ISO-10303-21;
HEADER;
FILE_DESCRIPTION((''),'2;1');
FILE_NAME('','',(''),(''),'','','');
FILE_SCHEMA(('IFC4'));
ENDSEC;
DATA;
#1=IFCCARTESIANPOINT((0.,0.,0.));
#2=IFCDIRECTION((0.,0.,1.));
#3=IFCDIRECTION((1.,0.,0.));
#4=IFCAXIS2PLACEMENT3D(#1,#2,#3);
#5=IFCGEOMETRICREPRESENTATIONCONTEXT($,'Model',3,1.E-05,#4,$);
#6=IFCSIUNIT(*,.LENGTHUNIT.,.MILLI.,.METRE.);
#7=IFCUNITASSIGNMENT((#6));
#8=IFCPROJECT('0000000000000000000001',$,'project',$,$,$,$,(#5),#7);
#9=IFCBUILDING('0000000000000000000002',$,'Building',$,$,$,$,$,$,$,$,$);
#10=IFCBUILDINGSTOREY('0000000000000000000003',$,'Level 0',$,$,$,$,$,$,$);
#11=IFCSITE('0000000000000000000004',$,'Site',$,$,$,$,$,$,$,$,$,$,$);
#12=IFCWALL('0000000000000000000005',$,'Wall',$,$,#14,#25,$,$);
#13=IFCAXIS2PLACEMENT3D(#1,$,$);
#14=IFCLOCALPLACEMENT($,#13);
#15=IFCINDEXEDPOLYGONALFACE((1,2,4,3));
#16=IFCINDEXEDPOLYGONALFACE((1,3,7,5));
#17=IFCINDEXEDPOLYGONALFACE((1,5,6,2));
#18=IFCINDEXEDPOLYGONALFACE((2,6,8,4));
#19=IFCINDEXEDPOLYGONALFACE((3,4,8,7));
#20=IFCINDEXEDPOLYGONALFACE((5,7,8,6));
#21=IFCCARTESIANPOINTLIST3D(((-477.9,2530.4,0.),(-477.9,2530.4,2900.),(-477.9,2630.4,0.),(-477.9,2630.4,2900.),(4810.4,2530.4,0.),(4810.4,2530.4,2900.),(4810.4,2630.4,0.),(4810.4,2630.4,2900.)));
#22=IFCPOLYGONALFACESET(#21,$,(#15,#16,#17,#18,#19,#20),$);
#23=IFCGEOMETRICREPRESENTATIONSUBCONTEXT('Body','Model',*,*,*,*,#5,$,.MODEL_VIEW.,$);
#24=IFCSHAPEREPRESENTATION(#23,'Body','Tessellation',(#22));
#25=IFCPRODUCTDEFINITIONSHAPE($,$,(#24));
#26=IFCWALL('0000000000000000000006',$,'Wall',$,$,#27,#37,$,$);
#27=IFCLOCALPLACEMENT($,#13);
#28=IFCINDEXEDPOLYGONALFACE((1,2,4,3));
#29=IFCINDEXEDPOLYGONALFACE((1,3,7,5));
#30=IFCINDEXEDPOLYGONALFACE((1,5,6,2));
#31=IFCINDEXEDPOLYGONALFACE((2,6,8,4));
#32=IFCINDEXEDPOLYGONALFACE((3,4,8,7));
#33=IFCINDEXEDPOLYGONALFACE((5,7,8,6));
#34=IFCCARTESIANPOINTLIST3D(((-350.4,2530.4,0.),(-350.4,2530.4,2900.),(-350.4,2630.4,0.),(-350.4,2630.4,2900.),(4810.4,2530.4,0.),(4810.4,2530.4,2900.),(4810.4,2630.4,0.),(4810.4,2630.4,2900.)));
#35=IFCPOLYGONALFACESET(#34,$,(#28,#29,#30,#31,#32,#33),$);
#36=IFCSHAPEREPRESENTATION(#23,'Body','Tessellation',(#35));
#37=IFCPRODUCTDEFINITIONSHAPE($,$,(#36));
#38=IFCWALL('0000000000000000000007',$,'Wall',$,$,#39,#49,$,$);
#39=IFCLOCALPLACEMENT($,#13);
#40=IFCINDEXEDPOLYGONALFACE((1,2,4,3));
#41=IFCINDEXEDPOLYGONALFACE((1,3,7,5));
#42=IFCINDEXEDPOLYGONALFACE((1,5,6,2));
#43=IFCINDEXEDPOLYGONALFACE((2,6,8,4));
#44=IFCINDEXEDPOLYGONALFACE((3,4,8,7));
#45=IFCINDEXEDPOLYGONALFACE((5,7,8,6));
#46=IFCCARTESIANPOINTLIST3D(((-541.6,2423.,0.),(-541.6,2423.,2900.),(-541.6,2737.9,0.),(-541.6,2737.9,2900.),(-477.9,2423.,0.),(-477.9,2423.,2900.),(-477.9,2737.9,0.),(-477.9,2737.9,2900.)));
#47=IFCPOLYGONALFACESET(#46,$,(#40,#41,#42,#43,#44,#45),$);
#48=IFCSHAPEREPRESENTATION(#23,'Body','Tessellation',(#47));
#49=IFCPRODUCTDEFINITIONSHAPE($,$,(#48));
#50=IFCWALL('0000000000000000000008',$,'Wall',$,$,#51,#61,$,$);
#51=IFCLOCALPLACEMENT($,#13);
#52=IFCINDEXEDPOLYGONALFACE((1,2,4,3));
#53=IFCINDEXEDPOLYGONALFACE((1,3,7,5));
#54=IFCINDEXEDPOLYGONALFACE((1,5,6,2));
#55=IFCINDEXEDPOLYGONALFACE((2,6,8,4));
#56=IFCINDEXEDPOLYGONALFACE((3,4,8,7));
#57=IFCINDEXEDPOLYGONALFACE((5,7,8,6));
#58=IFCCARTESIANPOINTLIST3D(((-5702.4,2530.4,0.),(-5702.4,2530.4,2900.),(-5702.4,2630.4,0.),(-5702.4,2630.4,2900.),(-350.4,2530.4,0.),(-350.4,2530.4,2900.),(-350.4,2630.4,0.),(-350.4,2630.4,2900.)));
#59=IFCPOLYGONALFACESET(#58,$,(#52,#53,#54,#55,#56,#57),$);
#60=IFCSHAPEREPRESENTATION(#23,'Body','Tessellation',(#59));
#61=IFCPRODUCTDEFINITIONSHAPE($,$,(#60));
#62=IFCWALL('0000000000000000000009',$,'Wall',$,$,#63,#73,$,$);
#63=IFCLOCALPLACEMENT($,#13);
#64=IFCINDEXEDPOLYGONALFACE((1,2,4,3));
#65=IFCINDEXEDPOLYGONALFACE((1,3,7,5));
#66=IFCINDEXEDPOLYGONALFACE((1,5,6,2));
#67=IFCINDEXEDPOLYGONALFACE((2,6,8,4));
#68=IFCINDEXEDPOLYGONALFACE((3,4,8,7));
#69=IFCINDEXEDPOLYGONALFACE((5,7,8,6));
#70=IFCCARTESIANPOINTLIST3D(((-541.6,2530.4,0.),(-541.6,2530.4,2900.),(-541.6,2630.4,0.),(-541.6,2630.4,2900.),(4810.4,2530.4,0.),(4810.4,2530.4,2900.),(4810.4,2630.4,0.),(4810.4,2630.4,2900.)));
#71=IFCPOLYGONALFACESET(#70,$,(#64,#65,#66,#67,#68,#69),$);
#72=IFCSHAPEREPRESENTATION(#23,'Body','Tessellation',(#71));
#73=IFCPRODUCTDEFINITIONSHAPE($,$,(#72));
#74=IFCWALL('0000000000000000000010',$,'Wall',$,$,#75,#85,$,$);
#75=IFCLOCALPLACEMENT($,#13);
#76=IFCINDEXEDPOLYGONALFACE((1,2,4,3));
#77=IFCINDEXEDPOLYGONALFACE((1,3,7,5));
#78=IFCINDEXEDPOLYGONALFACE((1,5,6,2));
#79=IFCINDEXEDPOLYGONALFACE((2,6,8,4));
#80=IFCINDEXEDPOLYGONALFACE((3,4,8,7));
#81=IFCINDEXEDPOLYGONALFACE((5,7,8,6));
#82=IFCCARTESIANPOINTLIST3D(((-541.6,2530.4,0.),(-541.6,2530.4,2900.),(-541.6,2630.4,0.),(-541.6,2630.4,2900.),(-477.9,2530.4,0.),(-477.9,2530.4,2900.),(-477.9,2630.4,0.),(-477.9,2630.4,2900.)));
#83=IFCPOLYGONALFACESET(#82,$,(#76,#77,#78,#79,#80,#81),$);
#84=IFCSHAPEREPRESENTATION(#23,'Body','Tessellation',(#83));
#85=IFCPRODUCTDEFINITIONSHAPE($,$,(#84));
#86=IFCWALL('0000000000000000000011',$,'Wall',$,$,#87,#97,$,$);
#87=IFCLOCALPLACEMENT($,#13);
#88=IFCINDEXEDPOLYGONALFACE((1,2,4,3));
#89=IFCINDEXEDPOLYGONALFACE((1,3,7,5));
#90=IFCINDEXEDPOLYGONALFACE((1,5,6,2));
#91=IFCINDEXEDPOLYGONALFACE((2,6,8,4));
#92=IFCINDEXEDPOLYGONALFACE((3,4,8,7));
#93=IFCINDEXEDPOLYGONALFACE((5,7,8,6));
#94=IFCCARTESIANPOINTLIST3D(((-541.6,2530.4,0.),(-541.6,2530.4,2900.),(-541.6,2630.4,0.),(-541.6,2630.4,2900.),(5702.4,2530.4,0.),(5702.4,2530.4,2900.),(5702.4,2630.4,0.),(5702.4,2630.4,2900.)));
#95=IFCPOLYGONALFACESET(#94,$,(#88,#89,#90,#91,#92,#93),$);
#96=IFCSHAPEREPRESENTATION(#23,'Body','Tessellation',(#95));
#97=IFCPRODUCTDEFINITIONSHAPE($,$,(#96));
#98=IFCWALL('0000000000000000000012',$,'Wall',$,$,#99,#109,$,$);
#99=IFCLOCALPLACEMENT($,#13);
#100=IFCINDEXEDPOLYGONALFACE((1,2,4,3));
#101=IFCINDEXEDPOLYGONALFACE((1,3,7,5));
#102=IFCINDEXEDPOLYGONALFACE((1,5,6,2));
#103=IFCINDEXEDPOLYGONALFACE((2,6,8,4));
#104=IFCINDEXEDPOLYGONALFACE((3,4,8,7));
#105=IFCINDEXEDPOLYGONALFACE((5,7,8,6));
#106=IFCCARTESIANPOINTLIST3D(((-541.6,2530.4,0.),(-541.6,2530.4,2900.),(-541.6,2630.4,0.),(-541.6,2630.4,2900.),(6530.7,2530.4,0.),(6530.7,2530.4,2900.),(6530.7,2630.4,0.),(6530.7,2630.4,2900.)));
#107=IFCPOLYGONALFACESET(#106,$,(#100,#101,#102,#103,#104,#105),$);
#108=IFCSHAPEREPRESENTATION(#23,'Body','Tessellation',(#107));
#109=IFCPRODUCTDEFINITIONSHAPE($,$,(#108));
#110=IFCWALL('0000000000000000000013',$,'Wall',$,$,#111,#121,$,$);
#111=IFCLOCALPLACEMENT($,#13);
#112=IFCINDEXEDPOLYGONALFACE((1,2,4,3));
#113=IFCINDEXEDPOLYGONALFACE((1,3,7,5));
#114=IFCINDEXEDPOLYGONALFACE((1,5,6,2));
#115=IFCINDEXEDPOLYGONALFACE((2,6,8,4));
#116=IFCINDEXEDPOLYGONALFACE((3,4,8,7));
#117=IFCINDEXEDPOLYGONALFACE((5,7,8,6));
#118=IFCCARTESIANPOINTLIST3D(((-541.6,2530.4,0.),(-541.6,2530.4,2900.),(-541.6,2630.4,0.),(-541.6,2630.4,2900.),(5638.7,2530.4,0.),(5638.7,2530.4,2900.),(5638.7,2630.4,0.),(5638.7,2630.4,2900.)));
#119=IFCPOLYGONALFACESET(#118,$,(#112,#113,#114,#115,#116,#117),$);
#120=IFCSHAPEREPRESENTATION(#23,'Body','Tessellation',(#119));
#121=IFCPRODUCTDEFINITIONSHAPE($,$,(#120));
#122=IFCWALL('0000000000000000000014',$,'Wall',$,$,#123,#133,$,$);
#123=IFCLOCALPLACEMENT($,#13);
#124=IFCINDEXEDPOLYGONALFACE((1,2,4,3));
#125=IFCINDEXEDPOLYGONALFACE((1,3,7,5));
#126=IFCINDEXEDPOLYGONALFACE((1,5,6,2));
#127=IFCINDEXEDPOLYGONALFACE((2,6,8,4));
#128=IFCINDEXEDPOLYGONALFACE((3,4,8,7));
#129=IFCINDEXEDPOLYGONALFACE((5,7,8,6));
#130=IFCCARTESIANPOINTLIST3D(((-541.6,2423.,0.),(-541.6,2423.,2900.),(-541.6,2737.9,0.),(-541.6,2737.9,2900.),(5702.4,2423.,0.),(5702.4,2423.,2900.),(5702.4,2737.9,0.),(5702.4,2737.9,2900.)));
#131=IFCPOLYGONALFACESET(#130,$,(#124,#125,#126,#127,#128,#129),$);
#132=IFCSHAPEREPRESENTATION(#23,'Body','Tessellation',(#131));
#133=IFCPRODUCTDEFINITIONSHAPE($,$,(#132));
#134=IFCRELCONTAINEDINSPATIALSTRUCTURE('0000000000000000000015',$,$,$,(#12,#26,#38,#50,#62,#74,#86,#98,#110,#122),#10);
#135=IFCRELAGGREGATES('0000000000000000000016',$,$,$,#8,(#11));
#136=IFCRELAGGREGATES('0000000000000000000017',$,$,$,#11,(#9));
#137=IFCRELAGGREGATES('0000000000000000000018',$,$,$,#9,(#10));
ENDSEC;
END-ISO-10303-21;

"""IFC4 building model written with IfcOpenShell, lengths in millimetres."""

from ifc_helpers import new_model, si_unit, frame, origin_with_axes, place, context, subcontext, project, spatial, indexed_curve, outline, extrude, element, save


model = new_model("IFC4")

# Units and contexts
model_context = context("Model", 3, precision=1e-05, world=origin_with_axes())
body_context = subcontext(model_context, "Body", "Model", "MODEL_VIEW")
ifc_project = project(units=[si_unit("LENGTHUNIT", "METRE", prefix="MILLI")], contexts=[model_context])

# Site, building, storey
site = spatial("IfcSite", under=ifc_project, Name="Site")
building = spatial("IfcBuilding", under=site, Name="Building")
storey = spatial("IfcBuildingStorey", under=building, Name="Level 0")

# Walls
wall_1_placement = place(None, frame((-477.9, 2530.4, 0.0), z_axis=(0.0, 0.0, 1.0), x_axis=(1.0, 0.0, 0.0)))
element("IfcWall", 1, at=wall_1_placement, inside=storey, Name="Wall", context=body_context, shape_type="SweptSolid", body=[
    extrude(outline(indexed_curve([(0.0, 0.0), (0.0, 99.9), (5288.3, 99.9), (5288.3, 0.0), (0.0, 0.0)], self_intersect=False)), origin_with_axes(), (0.0, 0.0, 1.0), 2900.0),
])
wall_2_placement = place(None, frame((-350.4, 2530.4, 0.0), z_axis=(0.0, 0.0, 1.0), x_axis=(1.0, 0.0, 0.0)))
element("IfcWall", 2, at=wall_2_placement, inside=storey, Name="Wall", context=body_context, shape_type="SweptSolid", body=[
    extrude(outline(indexed_curve([(0.0, 0.0), (0.0, 99.9), (5160.8, 99.9), (5160.8, 0.0), (0.0, 0.0)], self_intersect=False)), origin_with_axes(), (0.0, 0.0, 1.0), 2900.0),
])
wall_3_placement = place(None, frame((-477.9, 2737.9, 0.0), z_axis=(0.0, 0.0, 1.0), x_axis=(-1.0, 0.0, 0.0)))
element("IfcWall", 3, at=wall_3_placement, inside=storey, Name="Wall", context=body_context, shape_type="SweptSolid", body=[
    extrude(outline(indexed_curve([(0.0, 0.0), (0.0, 314.9), (63.7, 314.9), (63.7, 0.0), (0.0, 0.0)], self_intersect=False)), origin_with_axes(), (0.0, 0.0, 1.0), 2900.0),
])
wall_4_placement = place(None, frame((-350.4, 2630.4, 0.0), z_axis=(0.0, 0.0, 1.0), x_axis=(-1.0, 0.0, 0.0)))
element("IfcWall", 4, at=wall_4_placement, inside=storey, Name="Wall", context=body_context, shape_type="SweptSolid", body=[
    extrude(outline(indexed_curve([(0.0, 0.0), (0.0, 99.9), (5352.0, 99.9), (5352.0, 0.0), (0.0, 0.0)], self_intersect=False)), origin_with_axes(), (0.0, 0.0, 1.0), 2900.0),
])
wall_5_placement = place(None, frame((-541.6, 2530.4, 0.0), z_axis=(0.0, 0.0, 1.0), x_axis=(1.0, 0.0, 0.0)))
element("IfcWall", 5, at=wall_5_placement, inside=storey, Name="Wall", context=body_context, shape_type="SweptSolid", body=[
    extrude(outline(indexed_curve([(0.0, 0.0), (0.0, 99.9), (5352.0, 99.9), (5352.0, 0.0), (0.0, 0.0)], self_intersect=False)), origin_with_axes(), (0.0, 0.0, 1.0), 2900.0),
])
wall_6_placement = place(None, frame((-477.9, 2630.4, 0.0), z_axis=(0.0, 0.0, 1.0), x_axis=(-1.0, 0.0, 0.0)))
element("IfcWall", 6, at=wall_6_placement, inside=storey, Name="Wall", context=body_context, shape_type="SweptSolid", body=[
    extrude(outline(indexed_curve([(0.0, 0.0), (0.0, 99.9), (63.7, 99.9), (63.7, 0.0), (0.0, 0.0)], self_intersect=False)), origin_with_axes(), (0.0, 0.0, 1.0), 2900.0),
])
for number, where, z_axis, x_axis, name in (
    (7, (-541.6, 2530.4, 0.0), (0.0, 0.0, 1.0), (1.0, 0.0, 0.0), "Wall"),
):
    element("IfcWall", number, at=place(None, frame(where, z_axis=z_axis, x_axis=x_axis)), inside=storey, Name=name, context=body_context, shape_type="SweptSolid", body=[
        extrude(outline(indexed_curve([(0.0, 0.0), (0.0, 99.9), (6244.0, 99.9), (6244.0, 0.0), (0.0, 0.0)], self_intersect=False)), origin_with_axes(), (0.0, 0.0, 1.0), 2900.0),
    ])
wall_7_placement = place(None, frame((-541.6, 2530.4, 0.0), z_axis=(0.0, 0.0, 1.0), x_axis=(1.0, 0.0, 0.0)))
element("IfcWall", 8, at=wall_7_placement, inside=storey, Name="Wall", context=body_context, shape_type="SweptSolid", body=[
    extrude(outline(indexed_curve([(0.0, 0.0), (0.0, 99.9), (7072.3, 99.9), (7072.3, 0.0), (0.0, 0.0)], self_intersect=False)), origin_with_axes(), (0.0, 0.0, 1.0), 2900.0),
])
wall_8_placement = place(None, frame((-541.6, 2530.4, 0.0), z_axis=(0.0, 0.0, 1.0), x_axis=(1.0, 0.0, 0.0)))
element("IfcWall", 9, at=wall_8_placement, inside=storey, Name="Wall", context=body_context, shape_type="SweptSolid", body=[
    extrude(outline(indexed_curve([(0.0, 0.0), (0.0, 99.9), (6180.3, 99.9), (6180.3, 0.0), (0.0, 0.0)], self_intersect=False)), origin_with_axes(), (0.0, 0.0, 1.0), 2900.0),
])
wall_9_placement = place(None, frame((-541.6, 2423.0, 0.0), z_axis=(0.0, 0.0, 1.0), x_axis=(1.0, 0.0, 0.0)))
element("IfcWall", 10, at=wall_9_placement, inside=storey, Name="Wall", context=body_context, shape_type="SweptSolid", body=[
    extrude(outline(indexed_curve([(0.0, 0.0), (0.0, 314.9), (6244.0, 314.9), (6244.0, 0.0), (0.0, 0.0)], self_intersect=False)), origin_with_axes(), (0.0, 0.0, 1.0), 2900.0),
])

save(model, "model.ifc")
